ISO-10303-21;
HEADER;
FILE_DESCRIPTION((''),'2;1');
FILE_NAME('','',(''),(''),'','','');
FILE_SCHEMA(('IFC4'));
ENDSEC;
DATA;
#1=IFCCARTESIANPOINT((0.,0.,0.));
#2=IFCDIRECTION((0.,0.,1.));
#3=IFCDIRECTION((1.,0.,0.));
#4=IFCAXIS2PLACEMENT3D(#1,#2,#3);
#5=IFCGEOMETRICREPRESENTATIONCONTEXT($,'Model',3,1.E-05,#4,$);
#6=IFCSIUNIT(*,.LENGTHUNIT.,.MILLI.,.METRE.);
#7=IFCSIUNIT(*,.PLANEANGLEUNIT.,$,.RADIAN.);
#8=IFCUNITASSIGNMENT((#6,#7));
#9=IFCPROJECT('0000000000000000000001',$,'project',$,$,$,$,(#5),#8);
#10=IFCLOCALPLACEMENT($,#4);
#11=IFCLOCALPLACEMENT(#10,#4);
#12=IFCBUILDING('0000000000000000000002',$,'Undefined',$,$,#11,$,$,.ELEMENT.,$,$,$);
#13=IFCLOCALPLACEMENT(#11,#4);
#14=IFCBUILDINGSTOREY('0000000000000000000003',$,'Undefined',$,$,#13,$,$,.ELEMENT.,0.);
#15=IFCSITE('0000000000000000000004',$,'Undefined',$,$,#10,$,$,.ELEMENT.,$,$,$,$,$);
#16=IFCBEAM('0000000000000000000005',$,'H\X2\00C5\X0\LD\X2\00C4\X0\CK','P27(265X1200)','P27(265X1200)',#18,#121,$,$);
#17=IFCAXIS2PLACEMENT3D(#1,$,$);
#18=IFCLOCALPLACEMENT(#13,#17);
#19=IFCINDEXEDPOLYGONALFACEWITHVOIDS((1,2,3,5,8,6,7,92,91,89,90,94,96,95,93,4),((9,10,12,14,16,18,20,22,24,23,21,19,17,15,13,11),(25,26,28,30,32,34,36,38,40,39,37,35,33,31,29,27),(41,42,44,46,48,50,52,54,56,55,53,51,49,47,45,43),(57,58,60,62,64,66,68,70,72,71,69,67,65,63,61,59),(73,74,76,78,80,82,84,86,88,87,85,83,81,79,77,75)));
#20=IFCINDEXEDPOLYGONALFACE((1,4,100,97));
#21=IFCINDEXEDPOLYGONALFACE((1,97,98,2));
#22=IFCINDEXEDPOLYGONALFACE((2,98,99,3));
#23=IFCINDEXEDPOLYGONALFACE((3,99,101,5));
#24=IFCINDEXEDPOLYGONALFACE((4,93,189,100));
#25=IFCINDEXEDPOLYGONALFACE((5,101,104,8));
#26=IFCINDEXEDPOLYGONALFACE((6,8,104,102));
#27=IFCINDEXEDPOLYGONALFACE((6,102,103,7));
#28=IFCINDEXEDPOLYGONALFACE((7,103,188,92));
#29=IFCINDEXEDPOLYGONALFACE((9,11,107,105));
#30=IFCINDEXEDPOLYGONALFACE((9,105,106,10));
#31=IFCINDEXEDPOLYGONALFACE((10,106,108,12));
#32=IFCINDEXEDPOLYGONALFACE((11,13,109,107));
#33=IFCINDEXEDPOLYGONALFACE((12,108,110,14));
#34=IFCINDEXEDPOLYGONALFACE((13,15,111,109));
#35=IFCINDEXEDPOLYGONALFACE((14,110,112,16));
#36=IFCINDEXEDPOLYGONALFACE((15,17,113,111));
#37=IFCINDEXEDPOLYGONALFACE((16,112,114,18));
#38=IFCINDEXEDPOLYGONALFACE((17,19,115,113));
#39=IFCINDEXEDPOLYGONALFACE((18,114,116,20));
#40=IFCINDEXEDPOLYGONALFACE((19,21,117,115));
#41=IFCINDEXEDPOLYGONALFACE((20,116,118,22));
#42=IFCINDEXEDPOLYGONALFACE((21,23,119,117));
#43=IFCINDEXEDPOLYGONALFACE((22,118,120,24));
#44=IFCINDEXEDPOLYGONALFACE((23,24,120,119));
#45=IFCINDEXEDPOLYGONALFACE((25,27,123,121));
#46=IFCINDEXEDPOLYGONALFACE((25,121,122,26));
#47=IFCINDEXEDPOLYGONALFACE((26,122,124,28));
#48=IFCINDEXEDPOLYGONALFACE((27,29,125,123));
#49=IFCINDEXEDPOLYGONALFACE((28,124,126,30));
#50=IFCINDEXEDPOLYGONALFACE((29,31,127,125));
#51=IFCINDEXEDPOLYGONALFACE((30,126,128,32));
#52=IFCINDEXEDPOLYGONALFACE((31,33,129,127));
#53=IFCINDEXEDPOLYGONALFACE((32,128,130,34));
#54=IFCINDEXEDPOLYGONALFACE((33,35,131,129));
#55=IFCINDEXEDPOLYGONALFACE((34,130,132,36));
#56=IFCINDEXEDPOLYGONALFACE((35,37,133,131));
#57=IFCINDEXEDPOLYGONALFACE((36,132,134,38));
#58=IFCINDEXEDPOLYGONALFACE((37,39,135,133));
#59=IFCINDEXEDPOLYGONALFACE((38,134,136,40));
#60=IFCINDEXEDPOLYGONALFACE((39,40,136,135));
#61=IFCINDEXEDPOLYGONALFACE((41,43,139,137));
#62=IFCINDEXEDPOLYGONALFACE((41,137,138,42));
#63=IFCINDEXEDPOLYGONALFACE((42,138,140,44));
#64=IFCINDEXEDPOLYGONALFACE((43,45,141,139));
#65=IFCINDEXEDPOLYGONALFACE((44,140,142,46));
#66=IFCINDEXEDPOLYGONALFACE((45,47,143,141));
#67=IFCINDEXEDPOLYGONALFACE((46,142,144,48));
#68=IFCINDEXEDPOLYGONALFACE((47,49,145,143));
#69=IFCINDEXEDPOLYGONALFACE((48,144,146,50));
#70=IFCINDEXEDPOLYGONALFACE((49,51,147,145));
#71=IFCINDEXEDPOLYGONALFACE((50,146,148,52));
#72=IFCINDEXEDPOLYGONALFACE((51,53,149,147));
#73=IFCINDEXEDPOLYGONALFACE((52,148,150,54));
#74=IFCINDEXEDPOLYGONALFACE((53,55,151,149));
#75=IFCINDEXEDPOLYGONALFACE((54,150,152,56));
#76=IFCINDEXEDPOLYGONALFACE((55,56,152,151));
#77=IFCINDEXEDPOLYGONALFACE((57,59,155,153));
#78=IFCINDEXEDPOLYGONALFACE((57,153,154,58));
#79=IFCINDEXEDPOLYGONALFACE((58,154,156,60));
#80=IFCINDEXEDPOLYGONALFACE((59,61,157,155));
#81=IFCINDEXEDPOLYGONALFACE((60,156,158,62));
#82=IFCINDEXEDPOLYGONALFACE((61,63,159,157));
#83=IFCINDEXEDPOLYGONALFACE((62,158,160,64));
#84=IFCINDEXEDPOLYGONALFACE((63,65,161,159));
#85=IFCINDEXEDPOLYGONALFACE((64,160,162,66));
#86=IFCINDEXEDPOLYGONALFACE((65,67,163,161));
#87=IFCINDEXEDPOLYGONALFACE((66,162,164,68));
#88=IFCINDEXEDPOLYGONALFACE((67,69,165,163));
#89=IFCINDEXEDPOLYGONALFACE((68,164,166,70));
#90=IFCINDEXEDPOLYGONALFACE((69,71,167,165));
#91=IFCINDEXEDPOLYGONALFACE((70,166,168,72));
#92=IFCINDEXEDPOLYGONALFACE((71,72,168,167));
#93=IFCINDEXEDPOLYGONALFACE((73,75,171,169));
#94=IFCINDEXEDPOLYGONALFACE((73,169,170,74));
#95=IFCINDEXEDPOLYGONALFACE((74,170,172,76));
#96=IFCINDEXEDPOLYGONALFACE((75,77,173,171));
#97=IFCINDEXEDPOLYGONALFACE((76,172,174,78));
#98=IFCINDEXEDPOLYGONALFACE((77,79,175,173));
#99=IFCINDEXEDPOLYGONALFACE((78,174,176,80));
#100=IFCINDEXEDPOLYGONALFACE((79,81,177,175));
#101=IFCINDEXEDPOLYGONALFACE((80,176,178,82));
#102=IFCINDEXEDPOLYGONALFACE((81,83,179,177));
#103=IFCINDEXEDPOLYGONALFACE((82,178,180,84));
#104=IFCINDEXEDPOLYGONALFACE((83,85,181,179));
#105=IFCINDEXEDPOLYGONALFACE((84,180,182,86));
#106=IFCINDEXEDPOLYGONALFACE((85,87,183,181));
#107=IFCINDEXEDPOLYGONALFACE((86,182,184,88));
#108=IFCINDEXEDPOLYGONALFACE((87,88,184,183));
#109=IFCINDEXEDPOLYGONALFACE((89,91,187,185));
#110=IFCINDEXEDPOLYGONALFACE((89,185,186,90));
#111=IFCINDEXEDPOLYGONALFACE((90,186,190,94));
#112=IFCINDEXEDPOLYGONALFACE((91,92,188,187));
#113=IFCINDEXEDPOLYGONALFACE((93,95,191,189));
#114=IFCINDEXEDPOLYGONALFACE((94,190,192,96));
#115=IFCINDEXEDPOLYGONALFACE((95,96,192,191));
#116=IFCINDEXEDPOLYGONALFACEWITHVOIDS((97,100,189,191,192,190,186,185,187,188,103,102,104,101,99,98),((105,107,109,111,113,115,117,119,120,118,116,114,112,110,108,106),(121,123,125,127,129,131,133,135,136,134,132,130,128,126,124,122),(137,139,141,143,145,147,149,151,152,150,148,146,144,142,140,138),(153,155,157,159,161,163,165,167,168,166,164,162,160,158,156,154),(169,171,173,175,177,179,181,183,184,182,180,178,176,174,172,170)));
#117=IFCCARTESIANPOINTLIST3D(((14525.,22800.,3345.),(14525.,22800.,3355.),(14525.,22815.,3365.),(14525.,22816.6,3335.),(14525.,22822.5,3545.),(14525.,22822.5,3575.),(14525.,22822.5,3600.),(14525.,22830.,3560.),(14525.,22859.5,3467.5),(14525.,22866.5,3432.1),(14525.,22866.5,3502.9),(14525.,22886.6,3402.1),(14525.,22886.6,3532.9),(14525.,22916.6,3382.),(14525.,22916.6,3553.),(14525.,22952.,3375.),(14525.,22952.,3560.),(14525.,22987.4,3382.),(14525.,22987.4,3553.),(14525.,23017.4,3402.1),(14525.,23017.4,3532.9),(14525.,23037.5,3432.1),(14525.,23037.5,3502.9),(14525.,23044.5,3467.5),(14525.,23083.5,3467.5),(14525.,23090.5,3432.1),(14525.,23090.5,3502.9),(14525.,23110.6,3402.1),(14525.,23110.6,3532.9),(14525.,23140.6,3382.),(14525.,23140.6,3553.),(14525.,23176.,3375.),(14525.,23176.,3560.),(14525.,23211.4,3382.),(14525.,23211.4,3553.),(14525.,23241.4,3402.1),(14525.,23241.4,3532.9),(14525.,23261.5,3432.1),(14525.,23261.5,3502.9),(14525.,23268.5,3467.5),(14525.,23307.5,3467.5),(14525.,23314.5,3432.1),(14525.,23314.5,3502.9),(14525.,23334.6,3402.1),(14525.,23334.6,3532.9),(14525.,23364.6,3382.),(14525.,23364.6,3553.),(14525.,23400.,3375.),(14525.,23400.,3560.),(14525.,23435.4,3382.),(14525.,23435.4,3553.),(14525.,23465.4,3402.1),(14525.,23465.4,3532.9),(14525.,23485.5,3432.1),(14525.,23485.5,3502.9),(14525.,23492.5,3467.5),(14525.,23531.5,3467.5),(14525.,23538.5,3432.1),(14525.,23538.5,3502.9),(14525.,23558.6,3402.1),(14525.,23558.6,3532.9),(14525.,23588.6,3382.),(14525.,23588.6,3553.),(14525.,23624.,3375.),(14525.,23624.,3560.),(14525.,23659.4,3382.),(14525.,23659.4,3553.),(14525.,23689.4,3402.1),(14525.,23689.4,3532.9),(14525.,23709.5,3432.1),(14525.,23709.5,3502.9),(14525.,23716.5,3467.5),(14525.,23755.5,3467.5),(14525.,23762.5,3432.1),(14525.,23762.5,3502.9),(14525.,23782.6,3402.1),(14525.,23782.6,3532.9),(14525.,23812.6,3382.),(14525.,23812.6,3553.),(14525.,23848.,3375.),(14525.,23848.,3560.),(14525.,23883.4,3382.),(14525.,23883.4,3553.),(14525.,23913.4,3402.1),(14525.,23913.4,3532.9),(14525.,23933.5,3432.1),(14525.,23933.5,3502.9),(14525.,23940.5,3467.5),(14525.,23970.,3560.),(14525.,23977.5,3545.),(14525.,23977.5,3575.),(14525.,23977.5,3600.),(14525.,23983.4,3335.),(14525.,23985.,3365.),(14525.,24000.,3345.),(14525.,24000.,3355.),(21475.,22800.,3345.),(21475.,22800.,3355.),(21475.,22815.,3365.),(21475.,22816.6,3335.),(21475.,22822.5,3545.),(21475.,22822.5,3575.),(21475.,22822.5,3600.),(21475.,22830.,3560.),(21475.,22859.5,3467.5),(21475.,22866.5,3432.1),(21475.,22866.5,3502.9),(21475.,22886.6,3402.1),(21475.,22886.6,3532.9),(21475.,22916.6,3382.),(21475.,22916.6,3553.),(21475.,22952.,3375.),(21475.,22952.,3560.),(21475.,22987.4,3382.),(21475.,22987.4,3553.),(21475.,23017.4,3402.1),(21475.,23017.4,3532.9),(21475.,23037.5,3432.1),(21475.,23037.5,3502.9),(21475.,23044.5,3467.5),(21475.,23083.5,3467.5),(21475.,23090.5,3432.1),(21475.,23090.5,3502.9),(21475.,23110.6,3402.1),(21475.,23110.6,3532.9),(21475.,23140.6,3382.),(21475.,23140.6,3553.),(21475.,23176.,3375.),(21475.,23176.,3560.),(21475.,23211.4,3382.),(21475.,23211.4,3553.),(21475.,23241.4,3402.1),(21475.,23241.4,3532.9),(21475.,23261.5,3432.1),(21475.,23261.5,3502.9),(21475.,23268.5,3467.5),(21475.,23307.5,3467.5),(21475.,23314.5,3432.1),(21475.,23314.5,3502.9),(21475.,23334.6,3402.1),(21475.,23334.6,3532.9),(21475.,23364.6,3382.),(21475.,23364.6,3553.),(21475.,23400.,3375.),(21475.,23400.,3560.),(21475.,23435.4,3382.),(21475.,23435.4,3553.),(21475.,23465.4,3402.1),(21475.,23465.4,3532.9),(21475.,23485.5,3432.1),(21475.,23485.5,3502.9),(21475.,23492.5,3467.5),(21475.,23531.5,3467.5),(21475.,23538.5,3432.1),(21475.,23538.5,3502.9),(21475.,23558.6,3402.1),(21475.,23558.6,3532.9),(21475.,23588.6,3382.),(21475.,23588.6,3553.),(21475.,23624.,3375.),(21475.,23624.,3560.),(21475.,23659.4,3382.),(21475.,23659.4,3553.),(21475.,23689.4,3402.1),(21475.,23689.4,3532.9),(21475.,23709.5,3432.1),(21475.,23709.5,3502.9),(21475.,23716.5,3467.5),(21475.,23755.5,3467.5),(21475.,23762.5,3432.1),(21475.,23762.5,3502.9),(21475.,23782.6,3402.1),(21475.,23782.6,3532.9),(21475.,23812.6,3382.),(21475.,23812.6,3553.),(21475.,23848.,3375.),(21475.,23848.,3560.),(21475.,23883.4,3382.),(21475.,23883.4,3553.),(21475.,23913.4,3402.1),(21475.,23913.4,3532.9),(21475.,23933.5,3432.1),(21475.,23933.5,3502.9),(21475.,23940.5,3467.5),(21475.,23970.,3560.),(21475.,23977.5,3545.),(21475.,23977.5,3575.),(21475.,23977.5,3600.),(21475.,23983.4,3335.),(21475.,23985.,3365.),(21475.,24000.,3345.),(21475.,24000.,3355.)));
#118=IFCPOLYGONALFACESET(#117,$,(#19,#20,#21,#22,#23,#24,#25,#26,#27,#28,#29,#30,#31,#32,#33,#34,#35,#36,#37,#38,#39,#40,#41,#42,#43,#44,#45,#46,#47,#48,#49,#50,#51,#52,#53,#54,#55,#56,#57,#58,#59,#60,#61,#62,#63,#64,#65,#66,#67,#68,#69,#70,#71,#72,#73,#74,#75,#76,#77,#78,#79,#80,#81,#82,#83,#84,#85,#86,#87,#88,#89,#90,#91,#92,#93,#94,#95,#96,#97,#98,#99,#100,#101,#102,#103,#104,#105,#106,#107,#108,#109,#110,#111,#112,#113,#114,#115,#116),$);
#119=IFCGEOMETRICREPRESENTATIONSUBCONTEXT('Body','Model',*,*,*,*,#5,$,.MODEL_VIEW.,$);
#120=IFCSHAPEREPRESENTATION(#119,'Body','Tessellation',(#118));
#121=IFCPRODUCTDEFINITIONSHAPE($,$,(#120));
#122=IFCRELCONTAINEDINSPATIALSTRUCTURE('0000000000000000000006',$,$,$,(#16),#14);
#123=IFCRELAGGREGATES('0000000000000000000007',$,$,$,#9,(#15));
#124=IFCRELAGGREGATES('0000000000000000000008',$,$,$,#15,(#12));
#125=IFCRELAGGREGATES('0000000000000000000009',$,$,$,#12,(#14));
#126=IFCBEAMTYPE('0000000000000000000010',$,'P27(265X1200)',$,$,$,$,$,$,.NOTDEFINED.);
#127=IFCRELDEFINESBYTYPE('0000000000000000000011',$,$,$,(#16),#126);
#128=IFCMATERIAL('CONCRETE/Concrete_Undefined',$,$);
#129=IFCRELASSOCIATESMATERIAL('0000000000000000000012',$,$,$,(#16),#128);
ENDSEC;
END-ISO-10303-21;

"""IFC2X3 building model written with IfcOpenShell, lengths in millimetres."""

from ifc_helpers import new_model, si_unit, frame, origin_with_axes, place, context, subcontext, project, spatial, polyline, outline, extrude, material, type_object, element, save


model = new_model("IFC2X3")

# Units and contexts
model_context = context("Model", 3, precision=1e-05, world=origin_with_axes())
body_context = subcontext(model_context, "Body", "Model", "MODEL_VIEW")
ifc_project = project(units=[si_unit("LENGTHUNIT", "METRE", prefix="MILLI"), si_unit("PLANEANGLEUNIT", "RADIAN")], contexts=[model_context])

# Site, building, storey
site_placement = place(None, origin_with_axes())
site = spatial("IfcSite", under=ifc_project, at=site_placement, Name="Undefined", CompositionType="ELEMENT")
building_placement = place(site_placement, origin_with_axes())
building = spatial("IfcBuilding", under=site, at=building_placement, Name="Undefined", CompositionType="ELEMENT")
storey_placement = place(building_placement, origin_with_axes())
storey = spatial("IfcBuildingStorey", under=building, at=storey_placement, Name="Undefined", CompositionType="ELEMENT", Elevation=0.0)

# Beam
ifc_material_1 = material(Name="CONCRETE/Concrete_Undefined")
beam_type_1 = type_object("IfcBeamType", Name="P27(265X1200)", PredefinedType="NOTDEFINED")
beam_1_placement = place(storey_placement, frame((14525.0, 23400.0, 3467.5), z_axis=(0.0, 0.0, 1.0), x_axis=(1.0, 0.0, 0.0)))
element("IfcBeam", 1, at=beam_1_placement, inside=storey, type_object=beam_type_1, material=ifc_material_1, Name="HÅLDÄCK", Description="P27(265X1200)", ObjectType="P27(265X1200)", context=body_context, shape_type="SweptSolid", body=[
    extrude(outline(polyline([(-583.4, -132.5), (-600.0, -122.5), (-600.0, -112.5), (-585.0, -102.5), (-577.5, 77.5), (-570.0, 92.5), (-577.5, 107.5), (-577.5, 132.5), (577.5, 132.5), (577.5, 107.5), (570.0, 92.5), (577.5, 77.5), (585.0, -102.5), (600.0, -112.5), (600.0, -122.5), (583.4, -132.5), (-583.4, -132.5)]), holes=[polyline([(-513.4, 65.4), (-533.5, 35.4), (-540.5, 0.0), (-533.5, -35.4), (-513.4, -65.4), (-483.4, -85.5), (-448.0, -92.5), (-412.6, -85.5), (-382.6, -65.4), (-362.5, -35.4), (-355.5, 0.0), (-362.5, 35.4), (-382.6, 65.4), (-412.6, 85.5), (-448.0, 92.5), (-483.4, 85.5), (-513.4, 65.4)]), polyline([(-289.4, 65.4), (-309.5, 35.4), (-316.5, 0.0), (-309.5, -35.4), (-289.4, -65.4), (-259.4, -85.5), (-224.0, -92.5), (-188.6, -85.5), (-158.6, -65.4), (-138.5, -35.4), (-131.5, 0.0), (-138.5, 35.4), (-158.6, 65.4), (-188.6, 85.5), (-224.0, 92.5), (-259.4, 85.5), (-289.4, 65.4)]), polyline([(-65.4, 65.4), (-85.5, 35.4), (-92.5, 0.0), (-85.5, -35.4), (-65.4, -65.4), (-35.4, -85.5), (0.0, -92.5), (35.4, -85.5), (65.4, -65.4), (85.5, -35.4), (92.5, 0.0), (85.5, 35.4), (65.4, 65.4), (35.4, 85.5), (0.0, 92.5), (-35.4, 85.5), (-65.4, 65.4)]), polyline([(158.6, 65.4), (138.5, 35.4), (131.5, 0.0), (138.5, -35.4), (158.6, -65.4), (188.6, -85.5), (224.0, -92.5), (259.4, -85.5), (289.4, -65.4), (309.5, -35.4), (316.5, 0.0), (309.5, 35.4), (289.4, 65.4), (259.4, 85.5), (224.0, 92.5), (188.6, 85.5), (158.6, 65.4)]), polyline([(382.6, 65.4), (362.5, 35.4), (355.5, 0.0), (362.5, -35.4), (382.6, -65.4), (412.6, -85.5), (448.0, -92.5), (483.4, -85.5), (513.4, -65.4), (533.5, -35.4), (540.5, 0.0), (533.5, 35.4), (513.4, 65.4), (483.4, 85.5), (448.0, 92.5), (412.6, 85.5), (382.6, 65.4)])]), frame((6950.0, 0.0, 0.0), z_axis=(-1.0, 0.0, 0.0), x_axis=(0.0, -1.0, 0.0)), (0.0, 0.0, 1.0), 6950.0),
])

save(model, "model.ifc")
